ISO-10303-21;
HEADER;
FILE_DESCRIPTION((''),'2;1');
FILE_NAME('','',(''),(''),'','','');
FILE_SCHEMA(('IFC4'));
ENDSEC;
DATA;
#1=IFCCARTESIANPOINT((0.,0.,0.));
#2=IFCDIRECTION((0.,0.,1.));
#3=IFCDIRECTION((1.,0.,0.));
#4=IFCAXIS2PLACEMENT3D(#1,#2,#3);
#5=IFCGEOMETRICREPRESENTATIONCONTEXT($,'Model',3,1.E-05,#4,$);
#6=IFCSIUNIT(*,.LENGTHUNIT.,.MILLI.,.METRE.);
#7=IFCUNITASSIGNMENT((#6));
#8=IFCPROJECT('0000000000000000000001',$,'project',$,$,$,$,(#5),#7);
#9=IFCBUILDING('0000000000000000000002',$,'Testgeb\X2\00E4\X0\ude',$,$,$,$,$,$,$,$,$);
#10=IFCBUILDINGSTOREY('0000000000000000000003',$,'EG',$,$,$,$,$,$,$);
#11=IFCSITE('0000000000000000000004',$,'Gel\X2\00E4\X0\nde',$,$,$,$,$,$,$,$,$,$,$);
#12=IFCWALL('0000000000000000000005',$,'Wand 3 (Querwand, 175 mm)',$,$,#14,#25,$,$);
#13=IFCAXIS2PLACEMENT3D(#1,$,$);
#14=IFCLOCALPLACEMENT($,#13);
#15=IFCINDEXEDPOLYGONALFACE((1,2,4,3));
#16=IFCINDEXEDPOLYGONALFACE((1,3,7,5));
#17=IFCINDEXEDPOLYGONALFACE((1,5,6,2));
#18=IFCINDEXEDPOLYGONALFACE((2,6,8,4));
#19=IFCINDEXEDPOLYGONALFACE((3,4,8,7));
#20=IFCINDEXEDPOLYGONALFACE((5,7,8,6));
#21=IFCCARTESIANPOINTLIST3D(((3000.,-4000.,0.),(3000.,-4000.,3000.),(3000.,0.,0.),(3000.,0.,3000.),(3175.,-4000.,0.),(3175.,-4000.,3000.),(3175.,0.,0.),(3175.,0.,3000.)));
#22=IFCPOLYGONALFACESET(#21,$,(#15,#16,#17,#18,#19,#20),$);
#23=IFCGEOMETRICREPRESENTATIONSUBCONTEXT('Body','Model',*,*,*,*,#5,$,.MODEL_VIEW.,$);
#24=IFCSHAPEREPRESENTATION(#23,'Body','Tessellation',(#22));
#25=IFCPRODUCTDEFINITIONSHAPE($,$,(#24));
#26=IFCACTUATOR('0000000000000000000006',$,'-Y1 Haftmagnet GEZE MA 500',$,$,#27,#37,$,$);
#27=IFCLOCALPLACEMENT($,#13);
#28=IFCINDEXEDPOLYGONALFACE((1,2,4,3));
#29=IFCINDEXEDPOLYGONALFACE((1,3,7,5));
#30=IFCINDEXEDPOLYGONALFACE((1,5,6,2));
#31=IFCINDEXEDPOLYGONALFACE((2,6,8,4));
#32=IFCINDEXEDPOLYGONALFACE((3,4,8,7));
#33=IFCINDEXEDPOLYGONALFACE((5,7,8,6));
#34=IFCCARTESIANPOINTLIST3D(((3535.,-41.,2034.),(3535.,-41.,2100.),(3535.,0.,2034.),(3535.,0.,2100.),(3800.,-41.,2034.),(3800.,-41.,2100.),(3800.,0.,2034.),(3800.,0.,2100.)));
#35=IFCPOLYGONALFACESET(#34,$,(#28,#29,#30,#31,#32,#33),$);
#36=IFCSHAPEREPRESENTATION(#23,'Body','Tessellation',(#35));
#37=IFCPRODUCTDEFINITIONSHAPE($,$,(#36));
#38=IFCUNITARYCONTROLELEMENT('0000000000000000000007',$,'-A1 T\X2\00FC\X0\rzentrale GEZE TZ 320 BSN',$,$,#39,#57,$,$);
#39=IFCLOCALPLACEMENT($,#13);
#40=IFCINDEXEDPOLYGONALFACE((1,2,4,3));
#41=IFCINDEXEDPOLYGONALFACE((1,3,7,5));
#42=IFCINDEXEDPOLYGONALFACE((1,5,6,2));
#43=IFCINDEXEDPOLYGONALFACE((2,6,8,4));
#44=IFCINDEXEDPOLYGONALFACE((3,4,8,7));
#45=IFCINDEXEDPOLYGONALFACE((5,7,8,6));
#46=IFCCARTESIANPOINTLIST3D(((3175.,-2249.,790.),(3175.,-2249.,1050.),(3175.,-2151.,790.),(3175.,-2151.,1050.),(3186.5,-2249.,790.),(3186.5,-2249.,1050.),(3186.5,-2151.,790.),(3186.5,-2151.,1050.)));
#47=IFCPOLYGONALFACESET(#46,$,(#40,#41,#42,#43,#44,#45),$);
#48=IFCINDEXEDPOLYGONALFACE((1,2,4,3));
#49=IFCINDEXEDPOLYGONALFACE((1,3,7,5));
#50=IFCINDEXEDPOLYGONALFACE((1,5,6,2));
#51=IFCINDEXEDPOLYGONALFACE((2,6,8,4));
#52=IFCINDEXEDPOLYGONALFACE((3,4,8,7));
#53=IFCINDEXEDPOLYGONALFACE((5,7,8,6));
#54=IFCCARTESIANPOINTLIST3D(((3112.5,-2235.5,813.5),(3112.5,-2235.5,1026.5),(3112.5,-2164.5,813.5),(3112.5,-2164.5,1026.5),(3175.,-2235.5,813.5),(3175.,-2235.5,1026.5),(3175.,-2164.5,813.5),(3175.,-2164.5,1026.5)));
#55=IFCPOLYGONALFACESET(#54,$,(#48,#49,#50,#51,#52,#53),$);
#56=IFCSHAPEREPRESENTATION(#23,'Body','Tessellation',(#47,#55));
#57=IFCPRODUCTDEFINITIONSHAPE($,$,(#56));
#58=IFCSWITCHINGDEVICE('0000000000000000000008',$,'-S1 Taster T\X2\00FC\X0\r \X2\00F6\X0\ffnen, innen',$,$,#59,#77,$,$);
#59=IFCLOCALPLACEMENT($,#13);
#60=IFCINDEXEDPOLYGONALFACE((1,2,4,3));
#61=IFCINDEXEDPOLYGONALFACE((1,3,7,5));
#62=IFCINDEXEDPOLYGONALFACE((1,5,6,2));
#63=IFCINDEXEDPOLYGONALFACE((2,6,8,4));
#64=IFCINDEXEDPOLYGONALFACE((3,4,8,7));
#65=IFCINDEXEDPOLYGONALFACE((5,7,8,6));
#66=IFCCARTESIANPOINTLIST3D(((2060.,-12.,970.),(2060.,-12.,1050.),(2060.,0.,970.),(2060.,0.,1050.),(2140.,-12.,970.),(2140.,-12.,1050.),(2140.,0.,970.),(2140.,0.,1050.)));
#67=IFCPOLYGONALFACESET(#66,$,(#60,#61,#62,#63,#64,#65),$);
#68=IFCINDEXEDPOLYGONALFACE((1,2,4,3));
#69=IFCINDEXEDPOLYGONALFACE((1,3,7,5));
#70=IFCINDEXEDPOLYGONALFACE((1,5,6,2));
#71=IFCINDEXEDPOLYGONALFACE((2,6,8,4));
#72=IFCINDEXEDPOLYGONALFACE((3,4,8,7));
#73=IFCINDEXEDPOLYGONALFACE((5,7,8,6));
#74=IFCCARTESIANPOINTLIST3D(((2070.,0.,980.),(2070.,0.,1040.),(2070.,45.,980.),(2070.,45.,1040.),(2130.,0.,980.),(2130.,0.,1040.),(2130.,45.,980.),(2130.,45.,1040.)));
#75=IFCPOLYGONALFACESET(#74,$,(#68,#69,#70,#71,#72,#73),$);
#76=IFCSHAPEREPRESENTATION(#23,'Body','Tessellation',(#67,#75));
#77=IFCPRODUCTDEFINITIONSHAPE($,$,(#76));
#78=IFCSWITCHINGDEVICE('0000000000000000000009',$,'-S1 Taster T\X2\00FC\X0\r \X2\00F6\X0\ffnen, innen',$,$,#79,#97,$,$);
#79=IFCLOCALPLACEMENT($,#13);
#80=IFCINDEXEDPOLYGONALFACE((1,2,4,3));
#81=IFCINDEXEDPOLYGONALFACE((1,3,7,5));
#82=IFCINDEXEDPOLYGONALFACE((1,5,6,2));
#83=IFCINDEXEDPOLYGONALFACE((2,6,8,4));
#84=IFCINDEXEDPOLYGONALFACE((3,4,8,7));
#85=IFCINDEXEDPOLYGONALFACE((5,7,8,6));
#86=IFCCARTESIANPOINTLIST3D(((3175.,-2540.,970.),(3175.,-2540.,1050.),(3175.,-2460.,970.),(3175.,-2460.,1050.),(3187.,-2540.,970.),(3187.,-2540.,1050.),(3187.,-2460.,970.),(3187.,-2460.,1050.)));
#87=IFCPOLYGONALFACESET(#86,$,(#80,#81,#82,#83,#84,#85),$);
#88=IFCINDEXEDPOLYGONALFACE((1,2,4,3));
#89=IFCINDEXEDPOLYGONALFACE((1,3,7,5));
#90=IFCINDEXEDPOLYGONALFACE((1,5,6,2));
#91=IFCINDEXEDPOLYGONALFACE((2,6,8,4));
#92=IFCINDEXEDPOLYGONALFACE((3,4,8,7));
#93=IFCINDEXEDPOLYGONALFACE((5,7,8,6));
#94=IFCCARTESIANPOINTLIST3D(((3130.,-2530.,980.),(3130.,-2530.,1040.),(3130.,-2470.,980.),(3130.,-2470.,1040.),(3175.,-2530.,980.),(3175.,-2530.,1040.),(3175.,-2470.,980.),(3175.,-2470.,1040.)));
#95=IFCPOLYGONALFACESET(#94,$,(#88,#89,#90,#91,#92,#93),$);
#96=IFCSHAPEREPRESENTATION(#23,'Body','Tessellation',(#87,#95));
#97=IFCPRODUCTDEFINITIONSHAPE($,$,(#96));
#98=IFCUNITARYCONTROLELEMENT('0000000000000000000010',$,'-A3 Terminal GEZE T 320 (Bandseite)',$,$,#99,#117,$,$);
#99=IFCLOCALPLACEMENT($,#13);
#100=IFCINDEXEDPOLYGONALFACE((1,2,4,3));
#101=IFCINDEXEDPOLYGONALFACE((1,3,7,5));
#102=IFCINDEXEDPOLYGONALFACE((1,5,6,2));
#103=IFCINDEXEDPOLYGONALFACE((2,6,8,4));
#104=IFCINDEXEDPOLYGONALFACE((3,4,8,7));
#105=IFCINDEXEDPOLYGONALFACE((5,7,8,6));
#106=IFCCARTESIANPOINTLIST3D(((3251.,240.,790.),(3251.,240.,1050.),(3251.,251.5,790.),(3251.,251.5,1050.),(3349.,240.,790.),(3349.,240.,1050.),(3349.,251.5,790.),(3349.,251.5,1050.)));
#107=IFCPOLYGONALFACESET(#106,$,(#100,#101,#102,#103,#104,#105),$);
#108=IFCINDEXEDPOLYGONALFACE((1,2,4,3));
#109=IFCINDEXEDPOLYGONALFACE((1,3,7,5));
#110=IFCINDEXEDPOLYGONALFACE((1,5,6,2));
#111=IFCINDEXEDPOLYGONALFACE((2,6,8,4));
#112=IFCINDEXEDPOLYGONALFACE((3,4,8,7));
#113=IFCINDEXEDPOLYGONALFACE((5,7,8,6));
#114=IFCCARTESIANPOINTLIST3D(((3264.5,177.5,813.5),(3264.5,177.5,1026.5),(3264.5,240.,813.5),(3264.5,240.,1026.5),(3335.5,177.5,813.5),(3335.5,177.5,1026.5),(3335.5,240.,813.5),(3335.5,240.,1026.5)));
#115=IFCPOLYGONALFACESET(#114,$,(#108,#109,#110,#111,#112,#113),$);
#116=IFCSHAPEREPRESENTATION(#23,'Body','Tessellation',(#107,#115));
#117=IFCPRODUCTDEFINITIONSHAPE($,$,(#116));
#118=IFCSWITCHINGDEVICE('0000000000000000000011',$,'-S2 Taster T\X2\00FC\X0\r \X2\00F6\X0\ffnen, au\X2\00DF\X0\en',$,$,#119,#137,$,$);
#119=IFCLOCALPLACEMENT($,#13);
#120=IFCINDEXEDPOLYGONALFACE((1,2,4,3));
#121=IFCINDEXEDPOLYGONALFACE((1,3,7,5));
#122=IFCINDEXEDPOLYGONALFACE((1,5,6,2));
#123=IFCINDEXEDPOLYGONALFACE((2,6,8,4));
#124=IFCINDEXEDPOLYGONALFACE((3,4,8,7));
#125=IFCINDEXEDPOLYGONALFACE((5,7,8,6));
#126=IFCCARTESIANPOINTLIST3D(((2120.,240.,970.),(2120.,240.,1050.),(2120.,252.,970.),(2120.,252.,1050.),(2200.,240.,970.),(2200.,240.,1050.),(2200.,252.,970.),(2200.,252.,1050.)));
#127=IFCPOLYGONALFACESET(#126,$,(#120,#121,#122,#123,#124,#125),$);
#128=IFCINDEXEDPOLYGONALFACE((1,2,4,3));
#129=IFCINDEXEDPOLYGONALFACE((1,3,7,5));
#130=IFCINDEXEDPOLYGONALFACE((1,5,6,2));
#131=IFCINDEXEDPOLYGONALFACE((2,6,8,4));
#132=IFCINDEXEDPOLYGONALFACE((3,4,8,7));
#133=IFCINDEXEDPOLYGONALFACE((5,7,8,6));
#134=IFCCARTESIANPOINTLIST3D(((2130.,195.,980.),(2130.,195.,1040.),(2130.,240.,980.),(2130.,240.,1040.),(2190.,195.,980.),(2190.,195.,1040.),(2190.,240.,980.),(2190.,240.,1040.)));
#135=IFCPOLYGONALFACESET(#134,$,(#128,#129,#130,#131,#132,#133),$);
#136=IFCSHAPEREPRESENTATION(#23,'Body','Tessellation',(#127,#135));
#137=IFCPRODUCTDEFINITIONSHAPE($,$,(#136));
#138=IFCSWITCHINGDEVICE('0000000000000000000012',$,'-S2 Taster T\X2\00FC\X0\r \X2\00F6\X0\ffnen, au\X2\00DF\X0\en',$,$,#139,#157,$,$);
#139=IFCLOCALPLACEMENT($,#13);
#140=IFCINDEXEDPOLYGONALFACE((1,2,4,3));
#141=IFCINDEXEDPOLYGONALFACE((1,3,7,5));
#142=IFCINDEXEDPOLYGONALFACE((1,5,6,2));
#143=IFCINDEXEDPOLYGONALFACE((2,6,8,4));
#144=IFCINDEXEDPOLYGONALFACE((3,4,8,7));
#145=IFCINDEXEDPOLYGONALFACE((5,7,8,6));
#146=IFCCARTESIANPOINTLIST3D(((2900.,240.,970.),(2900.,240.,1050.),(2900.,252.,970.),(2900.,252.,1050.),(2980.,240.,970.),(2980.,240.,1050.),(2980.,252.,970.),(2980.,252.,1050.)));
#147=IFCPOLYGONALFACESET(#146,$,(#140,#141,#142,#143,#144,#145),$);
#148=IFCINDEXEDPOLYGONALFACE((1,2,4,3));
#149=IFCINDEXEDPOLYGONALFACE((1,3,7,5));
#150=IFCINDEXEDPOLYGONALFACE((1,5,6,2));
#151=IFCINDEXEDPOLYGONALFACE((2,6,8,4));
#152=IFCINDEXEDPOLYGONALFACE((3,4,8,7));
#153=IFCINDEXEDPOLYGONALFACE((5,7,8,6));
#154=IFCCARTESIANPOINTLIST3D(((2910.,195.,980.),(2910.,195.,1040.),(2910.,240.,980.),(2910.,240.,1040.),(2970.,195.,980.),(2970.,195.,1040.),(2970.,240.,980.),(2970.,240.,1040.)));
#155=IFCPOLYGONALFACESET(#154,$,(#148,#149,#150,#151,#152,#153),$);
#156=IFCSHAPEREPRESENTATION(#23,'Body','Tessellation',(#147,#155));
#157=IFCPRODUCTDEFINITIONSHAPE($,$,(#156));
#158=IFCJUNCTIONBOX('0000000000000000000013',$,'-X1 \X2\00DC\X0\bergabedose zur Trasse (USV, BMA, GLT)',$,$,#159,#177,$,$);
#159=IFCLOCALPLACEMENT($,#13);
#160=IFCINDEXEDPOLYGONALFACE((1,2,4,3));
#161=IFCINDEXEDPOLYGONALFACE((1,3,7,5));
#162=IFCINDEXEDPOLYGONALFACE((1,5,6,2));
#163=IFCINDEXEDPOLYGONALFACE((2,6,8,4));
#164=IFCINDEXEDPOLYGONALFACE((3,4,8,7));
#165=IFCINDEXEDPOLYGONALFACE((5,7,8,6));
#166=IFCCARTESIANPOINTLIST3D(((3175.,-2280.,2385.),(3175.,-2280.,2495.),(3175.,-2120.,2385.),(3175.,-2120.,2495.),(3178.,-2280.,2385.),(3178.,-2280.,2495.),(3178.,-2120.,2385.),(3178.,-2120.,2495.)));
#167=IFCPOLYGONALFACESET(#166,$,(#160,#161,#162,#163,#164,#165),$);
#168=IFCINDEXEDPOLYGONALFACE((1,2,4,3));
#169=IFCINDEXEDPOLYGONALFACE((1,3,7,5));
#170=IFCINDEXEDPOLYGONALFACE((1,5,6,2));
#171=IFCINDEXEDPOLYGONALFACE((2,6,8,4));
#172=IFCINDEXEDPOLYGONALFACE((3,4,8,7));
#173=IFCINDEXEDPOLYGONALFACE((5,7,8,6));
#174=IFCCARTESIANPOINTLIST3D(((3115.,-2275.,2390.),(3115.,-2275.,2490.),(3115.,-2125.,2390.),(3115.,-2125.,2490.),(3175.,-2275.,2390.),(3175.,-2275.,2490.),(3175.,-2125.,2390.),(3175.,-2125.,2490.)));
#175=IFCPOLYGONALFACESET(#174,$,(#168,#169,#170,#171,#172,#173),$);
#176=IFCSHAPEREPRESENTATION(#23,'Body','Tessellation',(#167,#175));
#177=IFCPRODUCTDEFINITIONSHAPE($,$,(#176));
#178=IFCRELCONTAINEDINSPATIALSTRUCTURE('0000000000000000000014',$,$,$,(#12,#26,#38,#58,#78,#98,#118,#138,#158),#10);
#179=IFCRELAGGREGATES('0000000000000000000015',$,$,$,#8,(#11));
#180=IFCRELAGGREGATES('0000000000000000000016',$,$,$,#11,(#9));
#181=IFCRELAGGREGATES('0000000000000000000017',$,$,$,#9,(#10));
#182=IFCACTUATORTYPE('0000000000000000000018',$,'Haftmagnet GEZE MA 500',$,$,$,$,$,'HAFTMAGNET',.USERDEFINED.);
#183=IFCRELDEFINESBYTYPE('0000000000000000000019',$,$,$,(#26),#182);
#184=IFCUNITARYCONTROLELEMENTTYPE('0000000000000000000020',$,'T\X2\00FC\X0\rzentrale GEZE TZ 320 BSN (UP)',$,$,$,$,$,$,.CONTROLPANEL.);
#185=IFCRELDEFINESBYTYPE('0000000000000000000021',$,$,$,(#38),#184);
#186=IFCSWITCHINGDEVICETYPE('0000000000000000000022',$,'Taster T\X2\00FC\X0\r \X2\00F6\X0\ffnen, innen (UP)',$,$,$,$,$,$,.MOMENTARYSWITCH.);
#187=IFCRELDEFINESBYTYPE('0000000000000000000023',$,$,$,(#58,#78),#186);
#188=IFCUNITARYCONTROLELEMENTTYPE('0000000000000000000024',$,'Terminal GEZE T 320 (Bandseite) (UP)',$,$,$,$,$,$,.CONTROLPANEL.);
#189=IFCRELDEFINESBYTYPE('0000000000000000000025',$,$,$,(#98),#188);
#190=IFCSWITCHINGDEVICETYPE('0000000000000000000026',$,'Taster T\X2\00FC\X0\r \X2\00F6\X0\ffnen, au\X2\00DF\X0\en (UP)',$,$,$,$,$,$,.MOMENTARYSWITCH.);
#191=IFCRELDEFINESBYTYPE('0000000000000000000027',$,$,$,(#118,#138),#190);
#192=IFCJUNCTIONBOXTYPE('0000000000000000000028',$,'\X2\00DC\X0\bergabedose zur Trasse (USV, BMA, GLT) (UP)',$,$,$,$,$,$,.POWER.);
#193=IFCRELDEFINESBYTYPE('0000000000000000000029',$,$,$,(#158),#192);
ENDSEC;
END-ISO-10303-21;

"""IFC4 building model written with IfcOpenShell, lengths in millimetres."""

from ifc_helpers import new_model, si_unit, frame, frame_2d, origin_with_axes, place, context, subcontext, project, spatial, rectangle, extrude, type_object, element, save


model = new_model("IFC4")

# Units and contexts
model_context = context("Model", 3, precision=1e-05, world=origin_with_axes())
body_context = subcontext(model_context, "Body", "Model", "MODEL_VIEW")
ifc_project = project(units=[si_unit("LENGTHUNIT", "METRE", prefix="MILLI")], contexts=[model_context])

# Site, building, storey
site = spatial("IfcSite", under=ifc_project, Name="Gelände")
building = spatial("IfcBuilding", under=site, Name="Testgebäude")
storey = spatial("IfcBuildingStorey", under=building, Name="EG")

# Wall
wall_placement = place(None, frame((3000.0, 0.0, 0.0), z_axis=(0.0, 0.0, 1.0), x_axis=(0.0, -1.0, 0.0)))
element("IfcWall", 1, at=wall_placement, inside=storey, Name="Wand 3 (Querwand, 175 mm)", context=body_context, shape_type="SweptSolid", body=[
    extrude(rectangle(XDim=4000.0, YDim=175.0, at=frame_2d((2000.0, 87.5))), None, (0.0, 0.0, 1.0), 3000.0),
])

# Actuator
actuator_type = type_object("IfcActuatorType", Name="Haftmagnet GEZE MA 500", ElementType="HAFTMAGNET", PredefinedType="USERDEFINED")
actuator_placement = place(None, frame((3535.0, -41.0, 2034.0), z_axis=(0.0, 0.0, 1.0), x_axis=(1.0, 0.0, 0.0)))
element("IfcActuator", 2, at=actuator_placement, inside=storey, type_object=actuator_type, Name="-Y1 Haftmagnet GEZE MA 500", context=body_context, shape_type="SweptSolid", body=[
    extrude(rectangle(XDim=265.0, YDim=41.0, at=frame_2d((132.5, 20.5))), None, (0.0, 0.0, 1.0), 66.0),
])

# Unitary control element
unitary_control_element_type_1 = type_object("IfcUnitaryControlElementType", Name="Türzentrale GEZE TZ 320 BSN (UP)", PredefinedType="CONTROLPANEL")
unitary_control_element_1_placement = place(None, frame((3175.0, -2249.0, 790.0), z_axis=(0.0, 0.0, 1.0), x_axis=(1.0, 0.0, 0.0)))
element("IfcUnitaryControlElement", 3, at=unitary_control_element_1_placement, inside=storey, type_object=unitary_control_element_type_1, Name="-A1 Türzentrale GEZE TZ 320 BSN", context=body_context, shape_type="SweptSolid", body=[
    extrude(rectangle(XDim=11.5, YDim=98.0, at=frame_2d((5.8, 49.0))), None, (0.0, 0.0, 1.0), 260.0),
    extrude(rectangle(XDim=62.5, YDim=71.0, at=frame_2d((31.2, 35.5))), frame((-62.5, 13.5, 23.5), z_axis=(0.0, 0.0, 1.0), x_axis=(1.0, 0.0, 0.0)), (0.0, 0.0, 1.0), 213.0),
])

# Switching devices
switching_device_type_1 = type_object("IfcSwitchingDeviceType", Name="Taster Tür öffnen, innen (UP)", PredefinedType="MOMENTARYSWITCH")
switching_device_1_placement = place(None, frame((2060.0, -12.0, 970.0), z_axis=(0.0, 0.0, 1.0), x_axis=(1.0, 0.0, 0.0)))
element("IfcSwitchingDevice", 4, at=switching_device_1_placement, inside=storey, type_object=switching_device_type_1, Name="-S1 Taster Tür öffnen, innen", context=body_context, shape_type="SweptSolid", body=[
    extrude(rectangle(XDim=80.0, YDim=12.0, at=frame_2d((40.0, 6.0))), None, (0.0, 0.0, 1.0), 80.0),
    extrude(rectangle(XDim=60.0, YDim=45.0, at=frame_2d((30.0, 22.5))), frame((10.0, 12.0, 10.0), z_axis=(0.0, 0.0, 1.0), x_axis=(1.0, 0.0, 0.0)), (0.0, 0.0, 1.0), 60.0),
])
switching_device_2_placement = place(None, frame((3175.0, -2540.0, 970.0), z_axis=(0.0, 0.0, 1.0), x_axis=(1.0, 0.0, 0.0)))
element("IfcSwitchingDevice", 5, at=switching_device_2_placement, inside=storey, type_object=switching_device_type_1, Name="-S1 Taster Tür öffnen, innen", context=body_context, shape_type="SweptSolid", body=[
    extrude(rectangle(XDim=12.0, YDim=80.0, at=frame_2d((6.0, 40.0))), None, (0.0, 0.0, 1.0), 80.0),
    extrude(rectangle(XDim=45.0, YDim=60.0, at=frame_2d((22.5, 30.0))), frame((-45.0, 10.0, 10.0), z_axis=(0.0, 0.0, 1.0), x_axis=(1.0, 0.0, 0.0)), (0.0, 0.0, 1.0), 60.0),
])

# Unitary control element
unitary_control_element_type_2 = type_object("IfcUnitaryControlElementType", Name="Terminal GEZE T 320 (Bandseite) (UP)", PredefinedType="CONTROLPANEL")
unitary_control_element_2_placement = place(None, frame((3251.0, 240.0, 790.0), z_axis=(0.0, 0.0, 1.0), x_axis=(1.0, 0.0, 0.0)))
element("IfcUnitaryControlElement", 6, at=unitary_control_element_2_placement, inside=storey, type_object=unitary_control_element_type_2, Name="-A3 Terminal GEZE T 320 (Bandseite)", context=body_context, shape_type="SweptSolid", body=[
    extrude(rectangle(XDim=98.0, YDim=11.5, at=frame_2d((49.0, 5.8))), None, (0.0, 0.0, 1.0), 260.0),
    extrude(rectangle(XDim=71.0, YDim=62.5, at=frame_2d((35.5, 31.2))), frame((13.5, -62.5, 23.5), z_axis=(0.0, 0.0, 1.0), x_axis=(1.0, 0.0, 0.0)), (0.0, 0.0, 1.0), 213.0),
])

# Switching devices
switching_device_type_2 = type_object("IfcSwitchingDeviceType", Name="Taster Tür öffnen, außen (UP)", PredefinedType="MOMENTARYSWITCH")
for number, where, z_axis, x_axis, name in (
    (7, (2120.0, 240.0, 970.0), (0.0, 0.0, 1.0), (1.0, 0.0, 0.0), "-S2 Taster Tür öffnen, außen"),
    (8, (2900.0, 240.0, 970.0), (0.0, 0.0, 1.0), (1.0, 0.0, 0.0), "-S2 Taster Tür öffnen, außen"),
):
    element("IfcSwitchingDevice", number, at=place(None, frame(where, z_axis=z_axis, x_axis=x_axis)), inside=storey, type_object=switching_device_type_2, Name=name, context=body_context, shape_type="SweptSolid", body=[
        extrude(rectangle(XDim=80.0, YDim=12.0, at=frame_2d((40.0, 6.0))), None, (0.0, 0.0, 1.0), 80.0),
        extrude(rectangle(XDim=60.0, YDim=45.0, at=frame_2d((30.0, 22.5))), frame((10.0, -45.0, 10.0), z_axis=(0.0, 0.0, 1.0), x_axis=(1.0, 0.0, 0.0)), (0.0, 0.0, 1.0), 60.0),
    ])

# Junction box
junction_box_type = type_object("IfcJunctionBoxType", Name="Übergabedose zur Trasse (USV, BMA, GLT) (UP)", PredefinedType="POWER")
junction_box_placement = place(None, frame((3175.0, -2280.0, 2385.0), z_axis=(0.0, 0.0, 1.0), x_axis=(1.0, 0.0, 0.0)))
element("IfcJunctionBox", 9, at=junction_box_placement, inside=storey, type_object=junction_box_type, Name="-X1 Übergabedose zur Trasse (USV, BMA, GLT)", context=body_context, shape_type="SweptSolid", body=[
    extrude(rectangle(XDim=3.0, YDim=160.0, at=frame_2d((1.5, 80.0))), None, (0.0, 0.0, 1.0), 110.0),
    extrude(rectangle(XDim=60.0, YDim=150.0, at=frame_2d((30.0, 75.0))), frame((-60.0, 5.0, 5.0), z_axis=(0.0, 0.0, 1.0), x_axis=(1.0, 0.0, 0.0)), (0.0, 0.0, 1.0), 100.0),
])

save(model, "model.ifc")
